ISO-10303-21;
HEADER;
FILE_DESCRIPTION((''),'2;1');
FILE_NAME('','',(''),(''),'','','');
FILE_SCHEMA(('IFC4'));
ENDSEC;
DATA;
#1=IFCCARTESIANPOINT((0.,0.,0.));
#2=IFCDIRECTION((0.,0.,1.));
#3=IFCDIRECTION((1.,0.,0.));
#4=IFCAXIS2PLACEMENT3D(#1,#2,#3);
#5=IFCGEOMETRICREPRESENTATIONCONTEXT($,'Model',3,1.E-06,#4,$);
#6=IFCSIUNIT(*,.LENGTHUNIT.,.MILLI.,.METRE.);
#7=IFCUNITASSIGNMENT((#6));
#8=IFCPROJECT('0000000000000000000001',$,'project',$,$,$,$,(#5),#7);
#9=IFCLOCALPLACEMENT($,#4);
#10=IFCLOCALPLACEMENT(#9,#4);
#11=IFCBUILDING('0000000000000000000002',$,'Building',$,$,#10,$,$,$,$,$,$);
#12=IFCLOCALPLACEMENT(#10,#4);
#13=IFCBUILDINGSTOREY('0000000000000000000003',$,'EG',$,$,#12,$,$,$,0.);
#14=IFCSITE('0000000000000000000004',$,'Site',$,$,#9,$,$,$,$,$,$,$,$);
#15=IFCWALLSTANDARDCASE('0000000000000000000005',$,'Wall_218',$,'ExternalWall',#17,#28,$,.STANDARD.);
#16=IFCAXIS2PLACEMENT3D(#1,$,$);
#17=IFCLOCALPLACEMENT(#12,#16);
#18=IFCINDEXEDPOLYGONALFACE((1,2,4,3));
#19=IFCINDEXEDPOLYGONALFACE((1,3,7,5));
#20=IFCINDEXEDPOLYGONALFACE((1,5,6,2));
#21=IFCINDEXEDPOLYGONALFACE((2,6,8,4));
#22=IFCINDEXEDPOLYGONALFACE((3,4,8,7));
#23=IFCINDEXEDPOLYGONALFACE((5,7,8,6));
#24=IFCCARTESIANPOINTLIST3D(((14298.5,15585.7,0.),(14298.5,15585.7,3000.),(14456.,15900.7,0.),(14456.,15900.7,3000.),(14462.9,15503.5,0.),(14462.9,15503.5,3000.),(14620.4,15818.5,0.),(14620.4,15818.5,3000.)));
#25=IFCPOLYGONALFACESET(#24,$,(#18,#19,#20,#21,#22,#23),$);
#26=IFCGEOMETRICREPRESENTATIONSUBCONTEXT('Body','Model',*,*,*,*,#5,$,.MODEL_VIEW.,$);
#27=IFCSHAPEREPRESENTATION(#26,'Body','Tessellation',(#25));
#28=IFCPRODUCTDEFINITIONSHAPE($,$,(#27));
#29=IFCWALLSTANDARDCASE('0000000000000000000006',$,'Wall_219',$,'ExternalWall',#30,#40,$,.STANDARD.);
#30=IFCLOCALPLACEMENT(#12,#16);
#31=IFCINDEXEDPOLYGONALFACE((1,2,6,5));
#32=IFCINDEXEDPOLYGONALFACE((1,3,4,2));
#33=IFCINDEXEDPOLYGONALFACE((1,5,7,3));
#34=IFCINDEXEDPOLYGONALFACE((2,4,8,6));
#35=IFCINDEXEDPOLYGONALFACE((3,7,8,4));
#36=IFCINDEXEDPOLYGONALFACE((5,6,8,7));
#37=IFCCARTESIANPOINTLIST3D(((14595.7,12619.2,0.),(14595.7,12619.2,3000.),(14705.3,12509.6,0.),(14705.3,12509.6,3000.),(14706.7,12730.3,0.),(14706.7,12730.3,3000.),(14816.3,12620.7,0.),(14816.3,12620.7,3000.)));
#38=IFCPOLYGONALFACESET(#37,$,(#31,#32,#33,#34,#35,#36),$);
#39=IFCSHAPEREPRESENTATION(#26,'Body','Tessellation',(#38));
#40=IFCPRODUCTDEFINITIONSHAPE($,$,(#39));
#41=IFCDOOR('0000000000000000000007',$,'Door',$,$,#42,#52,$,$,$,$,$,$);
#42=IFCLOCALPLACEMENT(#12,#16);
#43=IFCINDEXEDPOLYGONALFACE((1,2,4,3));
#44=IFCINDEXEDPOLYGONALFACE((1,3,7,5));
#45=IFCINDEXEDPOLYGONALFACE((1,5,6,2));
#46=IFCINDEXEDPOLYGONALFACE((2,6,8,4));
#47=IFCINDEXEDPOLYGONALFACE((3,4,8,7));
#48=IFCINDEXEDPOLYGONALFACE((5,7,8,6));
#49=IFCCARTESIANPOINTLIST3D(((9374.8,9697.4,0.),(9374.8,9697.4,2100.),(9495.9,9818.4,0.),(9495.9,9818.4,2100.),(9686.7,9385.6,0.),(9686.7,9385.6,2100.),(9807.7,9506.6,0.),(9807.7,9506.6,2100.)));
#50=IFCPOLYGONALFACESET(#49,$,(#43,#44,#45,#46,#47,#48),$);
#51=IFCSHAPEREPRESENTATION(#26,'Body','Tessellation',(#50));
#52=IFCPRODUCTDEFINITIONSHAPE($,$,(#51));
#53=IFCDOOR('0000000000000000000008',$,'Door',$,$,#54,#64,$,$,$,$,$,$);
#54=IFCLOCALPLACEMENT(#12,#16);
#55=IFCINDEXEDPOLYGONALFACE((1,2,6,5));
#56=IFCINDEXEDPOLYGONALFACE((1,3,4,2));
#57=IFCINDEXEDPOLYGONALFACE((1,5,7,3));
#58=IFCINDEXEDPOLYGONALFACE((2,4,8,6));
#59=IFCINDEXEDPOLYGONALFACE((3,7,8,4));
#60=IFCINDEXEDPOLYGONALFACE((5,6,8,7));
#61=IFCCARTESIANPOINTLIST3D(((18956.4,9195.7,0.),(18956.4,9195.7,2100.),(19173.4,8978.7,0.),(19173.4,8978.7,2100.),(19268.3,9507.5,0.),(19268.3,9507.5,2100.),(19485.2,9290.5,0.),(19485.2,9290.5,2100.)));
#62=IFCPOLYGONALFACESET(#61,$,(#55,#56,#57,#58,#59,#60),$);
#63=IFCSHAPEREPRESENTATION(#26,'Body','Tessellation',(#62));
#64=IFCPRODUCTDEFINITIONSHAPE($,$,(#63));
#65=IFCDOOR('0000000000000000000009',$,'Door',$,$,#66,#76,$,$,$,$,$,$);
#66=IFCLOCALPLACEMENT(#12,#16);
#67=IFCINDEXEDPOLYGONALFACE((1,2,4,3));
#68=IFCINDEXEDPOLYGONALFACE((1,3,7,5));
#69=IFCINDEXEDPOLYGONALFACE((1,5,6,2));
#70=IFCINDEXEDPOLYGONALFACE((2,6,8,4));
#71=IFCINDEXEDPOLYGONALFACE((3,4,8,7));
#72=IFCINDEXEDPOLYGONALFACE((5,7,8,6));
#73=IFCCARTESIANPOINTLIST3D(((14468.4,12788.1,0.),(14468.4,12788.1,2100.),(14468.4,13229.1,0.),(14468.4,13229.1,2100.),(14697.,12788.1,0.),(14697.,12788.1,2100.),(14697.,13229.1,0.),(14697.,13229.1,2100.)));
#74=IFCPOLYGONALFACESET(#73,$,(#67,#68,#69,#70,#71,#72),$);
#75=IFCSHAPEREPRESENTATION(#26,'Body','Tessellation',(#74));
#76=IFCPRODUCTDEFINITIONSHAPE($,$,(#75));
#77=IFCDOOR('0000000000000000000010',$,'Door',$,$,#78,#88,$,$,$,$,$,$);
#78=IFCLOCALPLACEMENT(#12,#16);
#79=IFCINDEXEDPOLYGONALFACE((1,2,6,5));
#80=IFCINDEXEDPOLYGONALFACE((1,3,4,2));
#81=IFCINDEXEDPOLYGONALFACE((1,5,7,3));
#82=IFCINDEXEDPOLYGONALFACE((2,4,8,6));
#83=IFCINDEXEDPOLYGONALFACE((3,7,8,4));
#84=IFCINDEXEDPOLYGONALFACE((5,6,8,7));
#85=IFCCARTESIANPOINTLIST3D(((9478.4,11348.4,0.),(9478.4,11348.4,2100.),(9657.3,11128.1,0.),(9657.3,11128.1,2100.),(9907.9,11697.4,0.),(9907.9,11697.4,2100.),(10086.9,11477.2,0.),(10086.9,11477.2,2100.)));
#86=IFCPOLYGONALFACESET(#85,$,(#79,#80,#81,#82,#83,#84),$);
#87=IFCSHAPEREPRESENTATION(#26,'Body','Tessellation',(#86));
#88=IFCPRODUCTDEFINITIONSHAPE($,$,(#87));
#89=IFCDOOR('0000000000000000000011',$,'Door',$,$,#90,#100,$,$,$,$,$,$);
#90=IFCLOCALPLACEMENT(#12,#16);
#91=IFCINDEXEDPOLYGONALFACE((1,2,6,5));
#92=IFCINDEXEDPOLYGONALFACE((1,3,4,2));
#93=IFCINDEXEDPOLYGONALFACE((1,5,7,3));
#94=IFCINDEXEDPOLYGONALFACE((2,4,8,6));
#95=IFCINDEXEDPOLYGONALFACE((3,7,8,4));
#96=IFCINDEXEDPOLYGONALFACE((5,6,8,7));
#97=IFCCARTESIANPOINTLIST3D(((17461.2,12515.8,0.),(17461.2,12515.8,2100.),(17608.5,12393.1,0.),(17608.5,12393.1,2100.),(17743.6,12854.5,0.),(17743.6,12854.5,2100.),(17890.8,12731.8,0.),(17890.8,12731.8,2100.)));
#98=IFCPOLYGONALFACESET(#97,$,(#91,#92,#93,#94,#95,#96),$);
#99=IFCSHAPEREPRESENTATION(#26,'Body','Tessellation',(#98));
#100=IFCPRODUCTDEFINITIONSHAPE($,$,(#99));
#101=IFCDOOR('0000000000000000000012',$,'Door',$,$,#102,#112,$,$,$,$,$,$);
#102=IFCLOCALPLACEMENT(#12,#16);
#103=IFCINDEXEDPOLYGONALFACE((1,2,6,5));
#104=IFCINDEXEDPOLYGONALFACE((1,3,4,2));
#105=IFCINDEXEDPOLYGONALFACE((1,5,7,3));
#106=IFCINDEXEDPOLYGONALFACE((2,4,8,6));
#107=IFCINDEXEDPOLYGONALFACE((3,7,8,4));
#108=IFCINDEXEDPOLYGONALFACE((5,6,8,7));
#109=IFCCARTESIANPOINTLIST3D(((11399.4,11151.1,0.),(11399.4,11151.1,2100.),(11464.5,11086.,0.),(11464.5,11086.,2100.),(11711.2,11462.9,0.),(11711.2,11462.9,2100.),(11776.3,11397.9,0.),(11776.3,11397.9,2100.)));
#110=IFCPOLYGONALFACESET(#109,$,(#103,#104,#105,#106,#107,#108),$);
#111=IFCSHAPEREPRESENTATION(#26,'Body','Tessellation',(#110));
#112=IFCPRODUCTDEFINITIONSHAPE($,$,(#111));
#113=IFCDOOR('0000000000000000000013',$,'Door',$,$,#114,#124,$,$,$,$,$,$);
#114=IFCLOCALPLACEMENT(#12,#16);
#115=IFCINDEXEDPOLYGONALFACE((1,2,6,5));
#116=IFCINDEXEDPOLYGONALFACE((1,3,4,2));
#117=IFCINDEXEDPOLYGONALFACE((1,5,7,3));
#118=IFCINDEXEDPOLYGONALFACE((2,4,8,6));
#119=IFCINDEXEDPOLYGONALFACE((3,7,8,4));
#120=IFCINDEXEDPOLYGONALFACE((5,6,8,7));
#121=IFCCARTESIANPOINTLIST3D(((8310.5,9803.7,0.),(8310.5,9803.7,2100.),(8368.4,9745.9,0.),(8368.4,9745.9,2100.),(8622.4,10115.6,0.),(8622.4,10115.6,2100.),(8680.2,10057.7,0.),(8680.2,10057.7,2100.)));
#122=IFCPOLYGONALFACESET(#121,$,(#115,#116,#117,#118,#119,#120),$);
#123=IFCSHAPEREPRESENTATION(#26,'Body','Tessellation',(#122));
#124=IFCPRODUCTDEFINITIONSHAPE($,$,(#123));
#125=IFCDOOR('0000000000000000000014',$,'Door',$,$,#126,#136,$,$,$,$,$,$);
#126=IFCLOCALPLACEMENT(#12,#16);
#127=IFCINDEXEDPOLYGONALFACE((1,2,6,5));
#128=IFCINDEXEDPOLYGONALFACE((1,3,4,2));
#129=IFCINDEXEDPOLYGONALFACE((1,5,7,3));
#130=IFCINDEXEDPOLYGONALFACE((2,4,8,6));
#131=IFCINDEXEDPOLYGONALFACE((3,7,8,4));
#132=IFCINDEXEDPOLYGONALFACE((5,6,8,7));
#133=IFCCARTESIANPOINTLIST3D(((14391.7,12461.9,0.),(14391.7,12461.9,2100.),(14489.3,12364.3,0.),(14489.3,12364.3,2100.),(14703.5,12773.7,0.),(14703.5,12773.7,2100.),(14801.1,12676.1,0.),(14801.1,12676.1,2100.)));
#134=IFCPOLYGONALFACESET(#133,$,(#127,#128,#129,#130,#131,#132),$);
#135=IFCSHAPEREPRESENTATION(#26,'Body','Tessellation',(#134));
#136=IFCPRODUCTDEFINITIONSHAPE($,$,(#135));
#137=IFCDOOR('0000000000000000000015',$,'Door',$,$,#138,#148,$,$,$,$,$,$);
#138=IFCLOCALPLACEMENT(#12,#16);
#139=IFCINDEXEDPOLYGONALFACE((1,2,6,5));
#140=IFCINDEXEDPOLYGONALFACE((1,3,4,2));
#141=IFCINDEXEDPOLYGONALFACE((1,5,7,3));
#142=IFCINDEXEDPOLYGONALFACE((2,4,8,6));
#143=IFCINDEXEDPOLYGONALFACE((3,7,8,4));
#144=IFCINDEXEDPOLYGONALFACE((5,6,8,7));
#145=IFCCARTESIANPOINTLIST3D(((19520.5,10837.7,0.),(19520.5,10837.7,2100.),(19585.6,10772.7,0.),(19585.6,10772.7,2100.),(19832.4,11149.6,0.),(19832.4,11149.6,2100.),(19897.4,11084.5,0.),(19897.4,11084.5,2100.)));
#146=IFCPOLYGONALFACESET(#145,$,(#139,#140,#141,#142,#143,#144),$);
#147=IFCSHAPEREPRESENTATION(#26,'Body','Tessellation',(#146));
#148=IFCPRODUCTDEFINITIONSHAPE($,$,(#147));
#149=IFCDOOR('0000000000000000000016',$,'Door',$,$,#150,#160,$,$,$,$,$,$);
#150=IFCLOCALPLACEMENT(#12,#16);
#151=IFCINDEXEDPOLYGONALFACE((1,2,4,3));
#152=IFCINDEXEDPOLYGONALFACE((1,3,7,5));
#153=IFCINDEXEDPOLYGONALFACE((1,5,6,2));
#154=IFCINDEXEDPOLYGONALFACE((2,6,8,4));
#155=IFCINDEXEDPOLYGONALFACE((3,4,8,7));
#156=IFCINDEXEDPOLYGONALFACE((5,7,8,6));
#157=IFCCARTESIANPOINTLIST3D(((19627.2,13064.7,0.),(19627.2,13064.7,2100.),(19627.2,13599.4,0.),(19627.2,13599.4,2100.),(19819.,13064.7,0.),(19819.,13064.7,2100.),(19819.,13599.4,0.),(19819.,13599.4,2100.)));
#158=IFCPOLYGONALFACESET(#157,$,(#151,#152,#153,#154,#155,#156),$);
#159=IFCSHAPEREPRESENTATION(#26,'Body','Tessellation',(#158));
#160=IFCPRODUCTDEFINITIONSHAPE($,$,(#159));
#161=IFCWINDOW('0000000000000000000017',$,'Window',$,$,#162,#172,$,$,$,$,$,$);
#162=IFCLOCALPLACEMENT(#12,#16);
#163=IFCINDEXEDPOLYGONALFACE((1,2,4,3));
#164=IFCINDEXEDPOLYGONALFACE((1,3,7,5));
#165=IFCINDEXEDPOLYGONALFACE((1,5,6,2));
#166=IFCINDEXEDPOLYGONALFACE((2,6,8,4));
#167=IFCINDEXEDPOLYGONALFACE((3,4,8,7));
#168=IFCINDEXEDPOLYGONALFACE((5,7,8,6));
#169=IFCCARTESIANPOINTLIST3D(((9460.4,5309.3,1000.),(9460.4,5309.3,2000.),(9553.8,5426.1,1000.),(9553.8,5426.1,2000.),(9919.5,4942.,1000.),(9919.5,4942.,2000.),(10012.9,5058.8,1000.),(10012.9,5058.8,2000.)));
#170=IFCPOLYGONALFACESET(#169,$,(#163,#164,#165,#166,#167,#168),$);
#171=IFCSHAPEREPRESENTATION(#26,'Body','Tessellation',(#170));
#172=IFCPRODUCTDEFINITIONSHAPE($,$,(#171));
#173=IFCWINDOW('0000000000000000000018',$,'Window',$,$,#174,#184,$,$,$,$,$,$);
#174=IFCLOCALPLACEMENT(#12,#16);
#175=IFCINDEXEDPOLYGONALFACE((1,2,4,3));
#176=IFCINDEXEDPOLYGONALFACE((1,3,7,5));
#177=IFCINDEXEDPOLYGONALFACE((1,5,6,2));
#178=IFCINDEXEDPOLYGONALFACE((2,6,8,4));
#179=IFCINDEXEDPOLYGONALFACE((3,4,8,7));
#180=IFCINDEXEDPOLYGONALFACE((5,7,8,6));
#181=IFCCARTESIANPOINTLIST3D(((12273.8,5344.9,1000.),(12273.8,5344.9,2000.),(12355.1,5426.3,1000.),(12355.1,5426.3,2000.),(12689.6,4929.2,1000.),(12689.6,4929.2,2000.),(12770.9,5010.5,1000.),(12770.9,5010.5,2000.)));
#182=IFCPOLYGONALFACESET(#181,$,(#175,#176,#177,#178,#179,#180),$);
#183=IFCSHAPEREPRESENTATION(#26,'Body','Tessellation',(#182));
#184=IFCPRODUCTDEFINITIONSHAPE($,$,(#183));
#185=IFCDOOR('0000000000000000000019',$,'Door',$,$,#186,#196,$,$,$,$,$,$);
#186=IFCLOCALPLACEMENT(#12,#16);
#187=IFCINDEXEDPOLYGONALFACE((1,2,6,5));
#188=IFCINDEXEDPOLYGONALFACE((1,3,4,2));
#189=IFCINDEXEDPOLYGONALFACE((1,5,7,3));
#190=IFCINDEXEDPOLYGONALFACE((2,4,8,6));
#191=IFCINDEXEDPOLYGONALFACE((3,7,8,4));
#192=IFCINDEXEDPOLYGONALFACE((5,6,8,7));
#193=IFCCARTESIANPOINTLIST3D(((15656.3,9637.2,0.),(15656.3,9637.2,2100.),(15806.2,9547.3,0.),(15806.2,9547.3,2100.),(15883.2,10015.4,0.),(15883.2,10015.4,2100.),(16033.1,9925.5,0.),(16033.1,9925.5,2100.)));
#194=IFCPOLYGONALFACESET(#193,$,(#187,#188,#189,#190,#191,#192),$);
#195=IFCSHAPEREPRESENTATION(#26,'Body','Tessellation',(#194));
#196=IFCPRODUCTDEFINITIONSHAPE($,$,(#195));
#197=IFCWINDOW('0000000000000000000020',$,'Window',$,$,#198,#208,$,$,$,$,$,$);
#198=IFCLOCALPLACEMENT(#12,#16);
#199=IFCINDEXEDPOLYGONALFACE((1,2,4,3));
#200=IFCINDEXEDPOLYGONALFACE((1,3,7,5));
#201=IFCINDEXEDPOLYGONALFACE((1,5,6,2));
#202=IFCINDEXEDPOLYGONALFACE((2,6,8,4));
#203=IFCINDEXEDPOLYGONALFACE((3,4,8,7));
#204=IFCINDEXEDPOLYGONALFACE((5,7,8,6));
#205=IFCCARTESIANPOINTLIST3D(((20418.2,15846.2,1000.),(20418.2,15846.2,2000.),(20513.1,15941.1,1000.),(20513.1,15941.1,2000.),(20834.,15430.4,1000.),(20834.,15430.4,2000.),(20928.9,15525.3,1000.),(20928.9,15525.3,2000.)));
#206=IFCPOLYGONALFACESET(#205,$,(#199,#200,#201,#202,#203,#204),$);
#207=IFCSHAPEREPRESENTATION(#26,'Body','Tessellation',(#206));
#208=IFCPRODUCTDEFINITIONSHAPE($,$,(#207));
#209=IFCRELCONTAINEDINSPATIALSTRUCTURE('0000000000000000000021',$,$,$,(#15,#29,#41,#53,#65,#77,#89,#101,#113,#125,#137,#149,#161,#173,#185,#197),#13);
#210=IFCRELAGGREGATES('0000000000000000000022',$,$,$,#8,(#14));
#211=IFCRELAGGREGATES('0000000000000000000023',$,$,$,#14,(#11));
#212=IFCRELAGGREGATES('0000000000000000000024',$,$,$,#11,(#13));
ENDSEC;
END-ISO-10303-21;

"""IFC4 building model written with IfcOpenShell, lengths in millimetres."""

from ifc_helpers import new_model, si_unit, frame, origin_with_axes, place, context, subcontext, project, spatial, rectangle, extrude, element, save


model = new_model("IFC4")

# Units and contexts
model_context = context("Model", 3, precision=1e-06, world=origin_with_axes())
body_context = subcontext(model_context, "Body", "Model", "MODEL_VIEW")
ifc_project = project(units=[si_unit("LENGTHUNIT", "METRE", prefix="MILLI")], contexts=[model_context])

# Site, building, storey
site_placement = place(None, origin_with_axes())
site = spatial("IfcSite", under=ifc_project, at=site_placement, Name="Site")
building_placement = place(site_placement, origin_with_axes())
building = spatial("IfcBuilding", under=site, at=building_placement, Name="Building")
storey_placement = place(building_placement, origin_with_axes())
storey = spatial("IfcBuildingStorey", under=building, at=storey_placement, Name="EG", Elevation=0.0)

# Walls
wall_1_placement = place(storey_placement, origin_with_axes())
element("IfcWallStandardCase", 1, at=wall_1_placement, inside=storey, Name="Wall_218", ObjectType="ExternalWall", PredefinedType="STANDARD", context=body_context, shape_type="SweptSolid", body=[
    extrude(rectangle(XDim=183.8, YDim=352.2), frame((14459.4, 15702.1, 0.0), z_axis=(0.0, 0.0, 1.0), x_axis=(-0.894427, 0.447214, 0.0)), (0.0, 0.0, 1.0), 3000.0),
])
wall_2_placement = place(storey_placement, origin_with_axes())
element("IfcWallStandardCase", 2, at=wall_2_placement, inside=storey, Name="Wall_219", ObjectType="ExternalWall", PredefinedType="STANDARD", context=body_context, shape_type="SweptSolid", body=[
    extrude(rectangle(XDim=155.0, YDim=157.0), frame((14706.0, 12619.9, 0.0), z_axis=(0.0, 0.0, 1.0), x_axis=(0.707107, -0.707107, 0.0)), (0.0, 0.0, 1.0), 3000.0),
])

# Doors
door_1_placement = place(storey_placement, origin_with_axes())
element("IfcDoor", 3, at=door_1_placement, inside=storey, Name="Door", context=body_context, shape_type="SweptSolid", body=[
    extrude(rectangle(XDim=441.0, YDim=171.1), frame((9591.3, 9602.0, 0.0), z_axis=(0.0, 0.0, 1.0), x_axis=(0.707107, -0.707107, 0.0)), (0.0, 0.0, 1.0), 2100.0),
])
door_2_placement = place(storey_placement, origin_with_axes())
element("IfcDoor", 4, at=door_2_placement, inside=storey, Name="Door", context=body_context, shape_type="SweptSolid", body=[
    extrude(rectangle(XDim=441.0, YDim=306.8), frame((19220.8, 9243.1, 0.0), z_axis=(0.0, 0.0, 1.0), x_axis=(-0.707107, -0.707107, 0.0)), (0.0, 0.0, 1.0), 2100.0),
])
door_3_placement = place(storey_placement, origin_with_axes())
element("IfcDoor", 5, at=door_3_placement, inside=storey, Name="Door", context=body_context, shape_type="SweptSolid", body=[
    extrude(rectangle(XDim=441.0, YDim=228.6), frame((14582.7, 13008.6, 0.0), z_axis=(0.0, 0.0, 1.0), x_axis=(0.0, -1.0, 0.0)), (0.0, 0.0, 1.0), 2100.0),
])
door_4_placement = place(storey_placement, origin_with_axes())
element("IfcDoor", 6, at=door_4_placement, inside=storey, Name="Door", context=body_context, shape_type="SweptSolid", body=[
    extrude(rectangle(XDim=553.5, YDim=283.8), frame((9782.6, 11412.8, 0.0), z_axis=(0.0, 0.0, 1.0), x_axis=(-0.776114, -0.630593, 0.0)), (0.0, 0.0, 1.0), 2100.0),
])
door_5_placement = place(storey_placement, origin_with_axes())
element("IfcDoor", 7, at=door_5_placement, inside=storey, Name="Door", context=body_context, shape_type="SweptSolid", body=[
    extrude(rectangle(XDim=441.0, YDim=191.7), frame((17676.0, 12623.8, 0.0), z_axis=(0.0, 0.0, 1.0), x_axis=(-0.640184, -0.768221, 0.0)), (0.0, 0.0, 1.0), 2100.0),
])
door_6_placement = place(storey_placement, origin_with_axes())
element("IfcDoor", 8, at=door_6_placement, inside=storey, Name="Door", context=body_context, shape_type="SweptSolid", body=[
    extrude(rectangle(XDim=441.0, YDim=92.0), frame((11587.8, 11274.5, 0.0), z_axis=(0.0, 0.0, 1.0), x_axis=(-0.707107, -0.707107, 0.0)), (0.0, 0.0, 1.0), 2100.0),
])
door_7_placement = place(storey_placement, origin_with_axes())
element("IfcDoor", 9, at=door_7_placement, inside=storey, Name="Door", context=body_context, shape_type="SweptSolid", body=[
    extrude(rectangle(XDim=441.0, YDim=81.8), frame((8495.4, 9930.7, 0.0), z_axis=(0.0, 0.0, 1.0), x_axis=(0.707107, 0.707107, 0.0)), (0.0, 0.0, 1.0), 2100.0),
])
door_8_placement = place(storey_placement, origin_with_axes())
element("IfcDoor", 10, at=door_8_placement, inside=storey, Name="Door", context=body_context, shape_type="SweptSolid", body=[
    extrude(rectangle(XDim=441.0, YDim=138.0), frame((14596.4, 12569.0, 0.0), z_axis=(0.0, 0.0, 1.0), x_axis=(-0.707107, -0.707107, 0.0)), (0.0, 0.0, 1.0), 2100.0),
])
door_9_placement = place(storey_placement, origin_with_axes())
element("IfcDoor", 11, at=door_9_placement, inside=storey, Name="Door", context=body_context, shape_type="SweptSolid", body=[
    extrude(rectangle(XDim=441.0, YDim=92.0), frame((19709.0, 10961.1, 0.0), z_axis=(0.0, 0.0, 1.0), x_axis=(-0.707107, -0.707107, 0.0)), (0.0, 0.0, 1.0), 2100.0),
])
door_10_placement = place(storey_placement, origin_with_axes())
element("IfcDoor", 12, at=door_10_placement, inside=storey, Name="Door", context=body_context, shape_type="SweptSolid", body=[
    extrude(rectangle(XDim=534.7, YDim=191.8), frame((19723.1, 13332.1, 0.0), z_axis=(0.0, 0.0, 1.0), x_axis=(0.0, -1.0, 0.0)), (0.0, 0.0, 1.0), 2100.0),
])

# Windows
window_1_placement = place(storey_placement, origin_with_axes())
element("IfcWindow", 13, at=window_1_placement, inside=storey, Name="Window", context=body_context, shape_type="SweptSolid", body=[
    extrude(rectangle(XDim=588.0, YDim=149.5), frame((9736.6, 5184.1, 1000.0), z_axis=(0.0, 0.0, 1.0), x_axis=(0.780869, -0.624695, 0.0)), (0.0, 0.0, 1.0), 1000.0),
])
window_2_placement = place(storey_placement, origin_with_axes())
element("IfcWindow", 14, at=window_2_placement, inside=storey, Name="Window", context=body_context, shape_type="SweptSolid", body=[
    extrude(rectangle(XDim=588.0, YDim=115.1), frame((12522.3, 5177.7, 1000.0), z_axis=(0.0, 0.0, 1.0), x_axis=(0.707107, -0.707107, 0.0)), (0.0, 0.0, 1.0), 1000.0),
])

# Door
door_11_placement = place(storey_placement, origin_with_axes())
element("IfcDoor", 15, at=door_11_placement, inside=storey, Name="Door", context=body_context, shape_type="SweptSolid", body=[
    extrude(rectangle(XDim=441.0, YDim=174.8), frame((15844.7, 9781.3, 0.0), z_axis=(0.0, 0.0, 1.0), x_axis=(0.514496, 0.857493, 0.0)), (0.0, 0.0, 1.0), 2100.0),
])

# Window
window_3_placement = place(storey_placement, origin_with_axes())
element("IfcWindow", 16, at=window_3_placement, inside=storey, Name="Window", context=body_context, shape_type="SweptSolid", body=[
    extrude(rectangle(XDim=588.0, YDim=134.2), frame((20673.6, 15685.8, 1000.0), z_axis=(0.0, 0.0, 1.0), x_axis=(0.707107, -0.707107, 0.0)), (0.0, 0.0, 1.0), 1000.0),
])

save(model, "model.ifc")
